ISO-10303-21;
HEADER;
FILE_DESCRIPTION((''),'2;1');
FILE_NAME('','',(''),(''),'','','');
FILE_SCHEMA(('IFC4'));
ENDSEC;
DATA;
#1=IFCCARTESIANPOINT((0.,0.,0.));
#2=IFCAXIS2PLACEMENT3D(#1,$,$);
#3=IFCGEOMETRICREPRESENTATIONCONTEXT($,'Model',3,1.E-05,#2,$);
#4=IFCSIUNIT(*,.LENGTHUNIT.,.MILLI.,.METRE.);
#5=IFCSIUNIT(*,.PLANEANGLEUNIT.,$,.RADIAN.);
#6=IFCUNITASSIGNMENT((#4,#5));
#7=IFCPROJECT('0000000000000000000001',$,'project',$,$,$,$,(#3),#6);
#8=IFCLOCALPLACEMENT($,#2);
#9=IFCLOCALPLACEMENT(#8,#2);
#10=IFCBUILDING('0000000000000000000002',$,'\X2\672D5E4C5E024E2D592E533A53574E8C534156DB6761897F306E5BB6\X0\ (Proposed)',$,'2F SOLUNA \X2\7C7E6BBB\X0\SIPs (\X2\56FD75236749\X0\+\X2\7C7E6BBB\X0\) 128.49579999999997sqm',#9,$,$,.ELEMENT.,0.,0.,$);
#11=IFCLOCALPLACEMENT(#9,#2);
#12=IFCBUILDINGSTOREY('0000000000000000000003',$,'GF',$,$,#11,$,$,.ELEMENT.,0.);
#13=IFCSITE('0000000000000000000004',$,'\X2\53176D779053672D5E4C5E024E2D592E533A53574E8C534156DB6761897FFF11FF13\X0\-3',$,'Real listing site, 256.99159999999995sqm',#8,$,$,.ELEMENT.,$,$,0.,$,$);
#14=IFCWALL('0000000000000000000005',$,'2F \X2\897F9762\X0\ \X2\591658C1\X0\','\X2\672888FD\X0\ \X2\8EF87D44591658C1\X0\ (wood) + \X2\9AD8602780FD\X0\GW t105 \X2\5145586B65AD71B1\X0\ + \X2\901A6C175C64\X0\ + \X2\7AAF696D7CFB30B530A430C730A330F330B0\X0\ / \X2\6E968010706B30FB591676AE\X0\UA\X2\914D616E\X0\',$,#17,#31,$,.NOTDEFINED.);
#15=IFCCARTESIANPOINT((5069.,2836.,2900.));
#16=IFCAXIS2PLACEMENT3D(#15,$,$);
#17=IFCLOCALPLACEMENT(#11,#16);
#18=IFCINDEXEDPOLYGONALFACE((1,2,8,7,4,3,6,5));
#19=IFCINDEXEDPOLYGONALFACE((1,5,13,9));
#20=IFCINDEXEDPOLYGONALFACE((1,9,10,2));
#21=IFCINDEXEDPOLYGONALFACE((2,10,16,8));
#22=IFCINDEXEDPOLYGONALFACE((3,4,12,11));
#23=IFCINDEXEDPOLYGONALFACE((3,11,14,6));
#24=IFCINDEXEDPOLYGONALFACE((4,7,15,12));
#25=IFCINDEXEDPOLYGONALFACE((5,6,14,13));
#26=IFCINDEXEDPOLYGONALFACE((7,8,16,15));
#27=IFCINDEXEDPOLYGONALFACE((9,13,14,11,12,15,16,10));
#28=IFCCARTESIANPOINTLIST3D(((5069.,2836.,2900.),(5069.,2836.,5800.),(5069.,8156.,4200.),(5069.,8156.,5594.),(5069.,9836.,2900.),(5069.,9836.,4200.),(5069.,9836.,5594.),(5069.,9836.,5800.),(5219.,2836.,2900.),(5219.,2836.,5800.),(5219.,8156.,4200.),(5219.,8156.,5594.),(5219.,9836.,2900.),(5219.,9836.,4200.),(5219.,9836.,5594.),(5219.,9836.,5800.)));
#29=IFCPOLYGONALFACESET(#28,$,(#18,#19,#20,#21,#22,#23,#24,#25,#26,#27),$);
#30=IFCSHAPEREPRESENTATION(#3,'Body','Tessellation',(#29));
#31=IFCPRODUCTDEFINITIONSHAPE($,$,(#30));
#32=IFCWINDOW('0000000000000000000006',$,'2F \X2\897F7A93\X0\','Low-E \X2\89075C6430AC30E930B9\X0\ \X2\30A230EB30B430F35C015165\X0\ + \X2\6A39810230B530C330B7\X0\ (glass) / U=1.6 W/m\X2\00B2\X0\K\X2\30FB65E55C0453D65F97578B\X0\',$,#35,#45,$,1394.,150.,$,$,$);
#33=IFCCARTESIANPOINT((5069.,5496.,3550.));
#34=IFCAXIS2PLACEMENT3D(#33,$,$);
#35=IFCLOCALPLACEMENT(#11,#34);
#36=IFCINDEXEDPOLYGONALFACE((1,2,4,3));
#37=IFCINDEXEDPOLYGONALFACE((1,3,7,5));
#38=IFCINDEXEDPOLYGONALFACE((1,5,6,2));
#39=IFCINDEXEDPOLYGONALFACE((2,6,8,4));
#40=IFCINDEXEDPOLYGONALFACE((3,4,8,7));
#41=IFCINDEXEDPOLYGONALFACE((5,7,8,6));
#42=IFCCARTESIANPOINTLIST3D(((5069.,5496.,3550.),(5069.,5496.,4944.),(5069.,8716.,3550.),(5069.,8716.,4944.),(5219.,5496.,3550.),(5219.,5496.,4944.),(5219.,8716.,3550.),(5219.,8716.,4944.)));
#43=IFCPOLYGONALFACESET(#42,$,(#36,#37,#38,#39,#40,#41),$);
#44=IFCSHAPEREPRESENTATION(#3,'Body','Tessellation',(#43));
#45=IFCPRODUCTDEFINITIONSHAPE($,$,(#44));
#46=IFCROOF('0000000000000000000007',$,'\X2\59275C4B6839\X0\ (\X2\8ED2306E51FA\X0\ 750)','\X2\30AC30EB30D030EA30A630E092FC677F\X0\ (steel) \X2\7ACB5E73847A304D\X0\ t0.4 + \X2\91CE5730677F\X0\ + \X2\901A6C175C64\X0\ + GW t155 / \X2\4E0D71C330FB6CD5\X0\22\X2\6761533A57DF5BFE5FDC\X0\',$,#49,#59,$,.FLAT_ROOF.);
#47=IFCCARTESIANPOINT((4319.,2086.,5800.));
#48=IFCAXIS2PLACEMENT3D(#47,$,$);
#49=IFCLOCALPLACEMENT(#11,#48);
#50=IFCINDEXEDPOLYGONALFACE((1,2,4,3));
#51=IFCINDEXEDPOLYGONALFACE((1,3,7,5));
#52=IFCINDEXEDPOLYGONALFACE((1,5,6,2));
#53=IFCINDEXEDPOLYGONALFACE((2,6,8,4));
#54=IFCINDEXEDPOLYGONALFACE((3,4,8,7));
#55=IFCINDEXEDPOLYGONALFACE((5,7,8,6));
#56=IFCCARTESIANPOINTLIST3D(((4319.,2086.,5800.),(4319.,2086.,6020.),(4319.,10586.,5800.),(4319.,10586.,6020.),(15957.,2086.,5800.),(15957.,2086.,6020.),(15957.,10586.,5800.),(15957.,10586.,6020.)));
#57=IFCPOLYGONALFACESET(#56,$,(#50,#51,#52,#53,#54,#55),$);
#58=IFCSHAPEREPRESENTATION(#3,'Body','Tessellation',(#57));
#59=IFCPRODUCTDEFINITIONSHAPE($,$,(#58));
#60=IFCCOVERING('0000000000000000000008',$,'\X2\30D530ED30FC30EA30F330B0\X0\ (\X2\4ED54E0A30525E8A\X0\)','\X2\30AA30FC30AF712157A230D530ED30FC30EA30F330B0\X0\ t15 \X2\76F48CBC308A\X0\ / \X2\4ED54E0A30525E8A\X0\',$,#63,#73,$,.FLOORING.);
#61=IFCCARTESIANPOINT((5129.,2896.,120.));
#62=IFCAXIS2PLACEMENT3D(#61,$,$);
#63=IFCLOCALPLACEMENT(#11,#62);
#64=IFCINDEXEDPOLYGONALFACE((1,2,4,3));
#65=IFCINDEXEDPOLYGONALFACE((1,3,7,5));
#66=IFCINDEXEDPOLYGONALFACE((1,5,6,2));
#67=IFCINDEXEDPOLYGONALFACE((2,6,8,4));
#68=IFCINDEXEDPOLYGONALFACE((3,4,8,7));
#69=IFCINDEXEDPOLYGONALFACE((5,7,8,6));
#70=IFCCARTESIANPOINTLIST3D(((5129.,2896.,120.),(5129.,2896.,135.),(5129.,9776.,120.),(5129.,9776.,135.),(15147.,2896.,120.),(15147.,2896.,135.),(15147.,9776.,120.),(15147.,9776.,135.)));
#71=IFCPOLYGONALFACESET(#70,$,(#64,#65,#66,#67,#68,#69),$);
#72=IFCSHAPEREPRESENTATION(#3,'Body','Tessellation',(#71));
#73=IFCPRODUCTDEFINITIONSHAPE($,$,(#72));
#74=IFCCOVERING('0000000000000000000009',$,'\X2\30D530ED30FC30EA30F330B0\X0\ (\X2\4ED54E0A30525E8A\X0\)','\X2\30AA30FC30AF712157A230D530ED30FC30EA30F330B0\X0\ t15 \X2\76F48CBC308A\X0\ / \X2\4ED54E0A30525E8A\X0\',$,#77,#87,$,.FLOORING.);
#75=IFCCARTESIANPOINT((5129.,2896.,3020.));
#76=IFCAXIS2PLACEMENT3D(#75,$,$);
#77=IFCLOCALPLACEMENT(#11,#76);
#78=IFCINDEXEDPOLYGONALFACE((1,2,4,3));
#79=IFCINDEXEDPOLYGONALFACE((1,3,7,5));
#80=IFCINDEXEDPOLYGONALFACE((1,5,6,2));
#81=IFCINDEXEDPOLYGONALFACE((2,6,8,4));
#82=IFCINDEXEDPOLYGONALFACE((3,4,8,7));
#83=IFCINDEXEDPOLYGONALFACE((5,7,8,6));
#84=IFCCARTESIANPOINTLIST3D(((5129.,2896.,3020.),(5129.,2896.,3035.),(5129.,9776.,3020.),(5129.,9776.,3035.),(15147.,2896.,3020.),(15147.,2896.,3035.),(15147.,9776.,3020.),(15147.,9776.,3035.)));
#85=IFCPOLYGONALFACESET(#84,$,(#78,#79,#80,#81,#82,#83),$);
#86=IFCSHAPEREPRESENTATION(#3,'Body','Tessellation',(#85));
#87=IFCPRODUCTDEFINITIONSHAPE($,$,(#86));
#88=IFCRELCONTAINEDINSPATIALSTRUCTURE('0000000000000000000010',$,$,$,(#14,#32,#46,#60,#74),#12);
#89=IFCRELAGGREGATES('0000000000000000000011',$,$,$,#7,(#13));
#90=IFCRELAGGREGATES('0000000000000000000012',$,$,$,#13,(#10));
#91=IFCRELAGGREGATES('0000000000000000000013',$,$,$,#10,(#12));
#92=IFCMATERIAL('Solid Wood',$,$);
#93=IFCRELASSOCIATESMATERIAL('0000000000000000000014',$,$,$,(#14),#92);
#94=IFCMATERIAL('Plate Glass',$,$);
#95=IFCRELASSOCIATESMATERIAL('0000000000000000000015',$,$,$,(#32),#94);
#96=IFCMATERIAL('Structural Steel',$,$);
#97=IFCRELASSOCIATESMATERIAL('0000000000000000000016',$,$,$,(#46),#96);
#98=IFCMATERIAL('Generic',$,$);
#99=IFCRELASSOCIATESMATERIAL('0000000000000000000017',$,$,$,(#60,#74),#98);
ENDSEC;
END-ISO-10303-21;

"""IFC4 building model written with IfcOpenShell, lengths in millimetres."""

from ifc_helpers import new_model, si_unit, frame, frame_2d, origin, place, context, project, spatial, rectangle, extrude, material, element, fill, save


model = new_model("IFC4")

# Units and contexts
model_context = context("Model", 3, precision=1e-05, world=origin())
ifc_project = project(units=[si_unit("LENGTHUNIT", "METRE", prefix="MILLI"), si_unit("PLANEANGLEUNIT", "RADIAN")], contexts=[model_context])

# Site, building, storey
site_placement = place(None, origin())
site = spatial("IfcSite", under=ifc_project, at=site_placement, Name="北海道札幌市中央区南二十四条西１３-3", ObjectType="Real listing site, 256.99159999999995sqm", CompositionType="ELEMENT", RefElevation=0.0)
building_placement = place(site_placement, origin())
building = spatial("IfcBuilding", under=site, at=building_placement, Name="札幌市中央区南二十四条西の家 (Proposed)", ObjectType="2F SOLUNA 籾殻SIPs (国産杉+籾殻) 128.49579999999997sqm", CompositionType="ELEMENT", ElevationOfRefHeight=0.0, ElevationOfTerrain=0.0)
storey_placement = place(building_placement, origin())
storey = spatial("IfcBuildingStorey", under=building, at=storey_placement, Name="GF", CompositionType="ELEMENT", Elevation=0.0)

# Shared definitions
ifc_material_1 = material(Name="Solid Wood")

# Shared definitions
ifc_material_2 = material(Name="Plate Glass")

# Wall, opening, window
wall_1_placement = place(storey_placement, frame((5069.0, 2836.0, 2900.0)))
wall_1 = element("IfcWall", 1, at=wall_1_placement, inside=storey, material=ifc_material_1, Name="2F 西面 外壁", Description="木製 軸組外壁 (wood) + 高性能GW t105 充填断熱 + 通気層 + 窯業系サイディング / 準耐火・外皮UA配慮", PredefinedType="NOTDEFINED", context=model_context, shape_type="SweptSolid", body=[
    extrude(rectangle(XDim=150.0, YDim=7000.0, at=frame_2d((75.0, 3500.0))), frame((5069.0, 2836.0, 2900.0)), (0.0, 0.0, 1.0), 2900.0),
])
opening_1_placement = place(storey_placement, frame((5069.0, 5496.0, 3550.0)))
opening_1 = element("IfcOpeningElement", 2, at=opening_1_placement, cuts=wall_1, PredefinedType="NOTDEFINED", context=model_context, shape_type="SweptSolid", body=[
    extrude(rectangle(XDim=150.0, YDim=3220.0, at=frame_2d((75.0, 1610.0))), frame((5069.0, 5496.0, 3550.0)), (0.0, 0.0, 1.0), 1394.0),
])
window_1_placement = place(storey_placement, frame((5069.0, 5496.0, 3550.0)))
window_1 = element("IfcWindow", 3, at=window_1_placement, inside=storey, material=ifc_material_2, Name="2F 西窓", Description="Low-E 複層ガラス アルゴン封入 + 樹脂サッシ (glass) / U=1.6 W/m²K・日射取得型", OverallHeight=1394.0, OverallWidth=150.0, context=model_context, shape_type="SweptSolid", body=[
    extrude(rectangle(XDim=150.0, YDim=3220.0, at=frame_2d((75.0, 1610.0))), frame((5069.0, 5496.0, 3550.0)), (0.0, 0.0, 1.0), 1394.0),
])
fill(opening_1, window_1)

# Roof
ifc_material_3 = material(Name="Structural Steel")
roof_placement = place(storey_placement, frame((4319.0, 2086.0, 5800.0)))
element("IfcRoof", 4, at=roof_placement, inside=storey, material=ifc_material_3, Name="大屋根 (軒の出 750)", Description="ガルバリウム鋼板 (steel) 立平葺き t0.4 + 野地板 + 通気層 + GW t155 / 不燃・法22条区域対応", PredefinedType="FLAT_ROOF", context=model_context, shape_type="SweptSolid", body=[
    extrude(rectangle(XDim=11638.0, YDim=8500.0, at=frame_2d((5819.0, 4250.0))), frame((4319.0, 2086.0, 5800.0)), (0.0, 0.0, 1.0), 220.0),
])

# Coverings
ifc_material_4 = material(Name="Generic")
covering_1_placement = place(storey_placement, frame((5129.0, 2896.0, 120.0)))
element("IfcCovering", 5, at=covering_1_placement, inside=storey, material=ifc_material_4, Name="フローリング (仕上げ床)", Description="オーク無垢フローリング t15 直貼り / 仕上げ床", PredefinedType="FLOORING", context=model_context, shape_type="SweptSolid", body=[
    extrude(rectangle(XDim=10018.0, YDim=6880.0, at=frame_2d((5009.0, 3440.0))), frame((5129.0, 2896.0, 120.0)), (0.0, 0.0, 1.0), 15.0),
])
covering_2_placement = place(storey_placement, frame((5129.0, 2896.0, 3020.0)))
element("IfcCovering", 6, at=covering_2_placement, inside=storey, material=ifc_material_4, Name="フローリング (仕上げ床)", Description="オーク無垢フローリング t15 直貼り / 仕上げ床", PredefinedType="FLOORING", context=model_context, shape_type="SweptSolid", body=[
    extrude(rectangle(XDim=10018.0, YDim=6880.0, at=frame_2d((5009.0, 3440.0))), frame((5129.0, 2896.0, 3020.0)), (0.0, 0.0, 1.0), 15.0),
])

save(model, "model.ifc")
